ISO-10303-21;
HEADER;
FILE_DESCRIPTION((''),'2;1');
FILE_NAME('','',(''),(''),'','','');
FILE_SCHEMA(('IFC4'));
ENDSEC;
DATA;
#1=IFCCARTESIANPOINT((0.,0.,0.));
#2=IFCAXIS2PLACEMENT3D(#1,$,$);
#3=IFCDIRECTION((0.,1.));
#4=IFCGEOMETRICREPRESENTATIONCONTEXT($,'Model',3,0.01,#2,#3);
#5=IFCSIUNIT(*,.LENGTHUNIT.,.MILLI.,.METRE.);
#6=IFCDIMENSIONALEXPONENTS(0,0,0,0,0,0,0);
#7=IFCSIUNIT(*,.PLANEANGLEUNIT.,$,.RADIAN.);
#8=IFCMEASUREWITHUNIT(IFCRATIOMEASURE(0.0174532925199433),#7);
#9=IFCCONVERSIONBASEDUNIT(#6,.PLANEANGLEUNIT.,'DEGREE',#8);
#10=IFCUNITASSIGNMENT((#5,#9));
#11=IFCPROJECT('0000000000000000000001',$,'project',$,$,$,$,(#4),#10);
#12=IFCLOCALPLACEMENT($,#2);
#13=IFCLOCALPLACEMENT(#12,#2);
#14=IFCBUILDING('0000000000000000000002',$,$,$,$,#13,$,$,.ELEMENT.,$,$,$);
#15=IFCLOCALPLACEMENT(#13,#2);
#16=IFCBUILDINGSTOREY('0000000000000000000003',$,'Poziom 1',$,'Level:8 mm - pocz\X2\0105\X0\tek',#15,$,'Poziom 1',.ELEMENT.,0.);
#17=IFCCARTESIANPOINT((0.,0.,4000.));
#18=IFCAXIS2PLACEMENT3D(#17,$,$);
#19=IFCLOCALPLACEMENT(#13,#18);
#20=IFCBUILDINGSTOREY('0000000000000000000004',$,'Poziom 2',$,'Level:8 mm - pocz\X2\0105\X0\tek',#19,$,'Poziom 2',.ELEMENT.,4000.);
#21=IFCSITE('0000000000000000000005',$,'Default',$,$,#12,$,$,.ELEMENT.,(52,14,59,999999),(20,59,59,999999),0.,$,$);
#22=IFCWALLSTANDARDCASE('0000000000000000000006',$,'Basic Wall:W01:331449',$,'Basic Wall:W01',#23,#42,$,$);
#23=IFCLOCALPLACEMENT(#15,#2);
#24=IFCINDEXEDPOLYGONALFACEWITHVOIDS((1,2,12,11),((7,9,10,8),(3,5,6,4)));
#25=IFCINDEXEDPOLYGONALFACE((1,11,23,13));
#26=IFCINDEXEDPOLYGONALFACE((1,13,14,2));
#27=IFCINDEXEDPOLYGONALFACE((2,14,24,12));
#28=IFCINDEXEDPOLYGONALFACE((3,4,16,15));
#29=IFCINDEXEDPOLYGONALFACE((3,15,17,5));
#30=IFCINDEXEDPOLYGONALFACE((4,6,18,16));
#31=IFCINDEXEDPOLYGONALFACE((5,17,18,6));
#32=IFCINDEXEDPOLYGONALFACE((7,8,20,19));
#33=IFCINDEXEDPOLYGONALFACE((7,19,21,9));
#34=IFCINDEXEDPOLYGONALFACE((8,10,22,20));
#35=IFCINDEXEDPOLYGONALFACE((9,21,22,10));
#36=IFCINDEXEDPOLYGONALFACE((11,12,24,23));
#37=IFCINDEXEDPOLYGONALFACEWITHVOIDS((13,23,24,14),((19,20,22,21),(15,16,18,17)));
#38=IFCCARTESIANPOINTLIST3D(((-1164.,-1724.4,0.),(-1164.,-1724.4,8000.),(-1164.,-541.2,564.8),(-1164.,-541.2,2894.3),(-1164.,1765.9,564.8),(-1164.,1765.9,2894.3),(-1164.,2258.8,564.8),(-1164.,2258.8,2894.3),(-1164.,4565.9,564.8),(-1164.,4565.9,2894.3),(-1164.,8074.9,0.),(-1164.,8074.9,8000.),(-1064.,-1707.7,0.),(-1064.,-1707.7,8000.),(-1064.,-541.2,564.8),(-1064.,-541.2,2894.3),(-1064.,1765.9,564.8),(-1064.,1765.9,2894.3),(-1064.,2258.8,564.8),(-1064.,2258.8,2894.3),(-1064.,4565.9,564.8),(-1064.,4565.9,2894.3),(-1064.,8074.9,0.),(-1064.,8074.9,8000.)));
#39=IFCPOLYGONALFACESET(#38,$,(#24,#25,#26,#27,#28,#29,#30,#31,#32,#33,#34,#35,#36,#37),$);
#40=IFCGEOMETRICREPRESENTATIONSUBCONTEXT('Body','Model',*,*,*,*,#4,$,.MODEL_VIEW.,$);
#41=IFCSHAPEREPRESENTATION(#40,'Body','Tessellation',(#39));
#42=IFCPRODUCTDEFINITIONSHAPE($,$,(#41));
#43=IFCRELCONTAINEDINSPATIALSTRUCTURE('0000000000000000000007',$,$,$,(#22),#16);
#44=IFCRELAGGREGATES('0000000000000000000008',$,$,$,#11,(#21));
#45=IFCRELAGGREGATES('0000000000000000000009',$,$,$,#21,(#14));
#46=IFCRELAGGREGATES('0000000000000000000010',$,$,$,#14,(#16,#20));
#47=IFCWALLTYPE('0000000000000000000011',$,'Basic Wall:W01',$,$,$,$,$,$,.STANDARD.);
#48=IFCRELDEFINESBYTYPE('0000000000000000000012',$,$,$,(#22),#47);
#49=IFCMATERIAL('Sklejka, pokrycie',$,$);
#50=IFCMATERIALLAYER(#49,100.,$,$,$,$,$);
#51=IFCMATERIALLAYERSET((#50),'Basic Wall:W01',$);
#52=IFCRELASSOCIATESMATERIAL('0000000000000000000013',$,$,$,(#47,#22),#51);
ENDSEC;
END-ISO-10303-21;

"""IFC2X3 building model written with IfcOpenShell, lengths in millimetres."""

from ifc_helpers import new_model, entity, si_unit, converted_unit, direction, frame, origin, origin_2d_with_axis, place, context, subcontext, project, spatial, polyline, rectangle, outline, extrude, material, layer, layer_set, layer_usage, type_object, element, save


model = new_model("IFC2X3")

# Units and contexts
model_context = context("Model", 3, precision=0.01, world=origin(), true_north=direction((0.0, 1.0)))
body_context = subcontext(model_context, "Body", "Model", "MODEL_VIEW")
ifc_project = project(units=[si_unit("LENGTHUNIT", "METRE", prefix="MILLI"), converted_unit("PLANEANGLEUNIT", "DEGREE", entity("IfcRatioMeasure", 0.0174532925199433), si_unit("PLANEANGLEUNIT", "RADIAN"), dimensions=[0, 0, 0, 0, 0, 0, 0])], contexts=[model_context])

# Site, building, storey
site_placement = place(None, origin())
site = spatial("IfcSite", under=ifc_project, at=site_placement, Name="Default", CompositionType="ELEMENT", RefLatitude=(52, 14, 59, 999999), RefLongitude=(20, 59, 59, 999999), RefElevation=0.0)
building_placement = place(site_placement, origin())
building = spatial("IfcBuilding", under=site, at=building_placement, CompositionType="ELEMENT")
storey_1_placement = place(building_placement, origin())
storey_1 = spatial("IfcBuildingStorey", under=building, at=storey_1_placement, Name="Poziom 1", ObjectType="Level:8 mm - początek", LongName="Poziom 1", CompositionType="ELEMENT", Elevation=0.0)

# Shared definitions
storey_2_placement = place(building_placement, frame((0.0, 0.0, 4000.0)))
storey_2 = spatial("IfcBuildingStorey", under=building, at=storey_2_placement, Name="Poziom 2", ObjectType="Level:8 mm - początek", LongName="Poziom 2", CompositionType="ELEMENT", Elevation=4000.0)

# Wall, openings
ifc_material_1 = material(Name="Sklejka, pokrycie")
ifc_layer_1 = layer(ifc_material_1, 100.0)
ifc_layer_set_1 = layer_set([ifc_layer_1], Name="Basic Wall:W01")
ifc_layer_usage_1 = layer_usage(ifc_layer_set_1, "AXIS2", "NEGATIVE", 50.0)
wall_type_1 = type_object("IfcWallType", Name="Basic Wall:W01", PredefinedType="STANDARD", material=ifc_layer_set_1)
wall_1_placement = place(storey_1_placement, frame((-1114.0, -1724.4, 0.0), z_axis=(0.0, 0.0, 1.0), x_axis=(0.0, 1.0, 0.0)))
wall_1 = element("IfcWallStandardCase", 1, at=wall_1_placement, inside=storey_1, type_object=wall_type_1, material=ifc_layer_usage_1, Name="Basic Wall:W01:331449", ObjectType="Basic Wall:W01", context=body_context, shape_type="SweptSolid", body=[
    extrude(outline(polyline([(9799.3, -50.0), (9799.3, 50.0), (0.0, 50.0), (16.7, -50.0), (9799.3, -50.0)])), origin(), (0.0, 0.0, 1.0), 8000.0),
])
opening_1_placement = place(wall_1_placement, origin())
element("IfcOpeningElement", 2, at=opening_1_placement, cuts=wall_1, ObjectType="Opening", context=body_context, shape_type="SweptSolid", body=[
    extrude(rectangle(XDim=2329.5, YDim=2307.1, at=origin_2d_with_axis()), frame((2336.8, -50.0, 1729.5), z_axis=(0.0, 1.0, 0.0), x_axis=(0.0, 0.0, -1.0)), (0.0, 0.0, 1.0), 100.0),
])
opening_2_placement = place(wall_1_placement, origin())
element("IfcOpeningElement", 3, at=opening_2_placement, cuts=wall_1, ObjectType="Opening", context=body_context, shape_type="SweptSolid", body=[
    extrude(rectangle(XDim=2329.5, YDim=2307.1, at=origin_2d_with_axis()), frame((5136.8, -50.0, 1729.5), z_axis=(0.0, 1.0, 0.0), x_axis=(0.0, 0.0, -1.0)), (0.0, 0.0, 1.0), 100.0),
])

save(model, "model.ifc")
